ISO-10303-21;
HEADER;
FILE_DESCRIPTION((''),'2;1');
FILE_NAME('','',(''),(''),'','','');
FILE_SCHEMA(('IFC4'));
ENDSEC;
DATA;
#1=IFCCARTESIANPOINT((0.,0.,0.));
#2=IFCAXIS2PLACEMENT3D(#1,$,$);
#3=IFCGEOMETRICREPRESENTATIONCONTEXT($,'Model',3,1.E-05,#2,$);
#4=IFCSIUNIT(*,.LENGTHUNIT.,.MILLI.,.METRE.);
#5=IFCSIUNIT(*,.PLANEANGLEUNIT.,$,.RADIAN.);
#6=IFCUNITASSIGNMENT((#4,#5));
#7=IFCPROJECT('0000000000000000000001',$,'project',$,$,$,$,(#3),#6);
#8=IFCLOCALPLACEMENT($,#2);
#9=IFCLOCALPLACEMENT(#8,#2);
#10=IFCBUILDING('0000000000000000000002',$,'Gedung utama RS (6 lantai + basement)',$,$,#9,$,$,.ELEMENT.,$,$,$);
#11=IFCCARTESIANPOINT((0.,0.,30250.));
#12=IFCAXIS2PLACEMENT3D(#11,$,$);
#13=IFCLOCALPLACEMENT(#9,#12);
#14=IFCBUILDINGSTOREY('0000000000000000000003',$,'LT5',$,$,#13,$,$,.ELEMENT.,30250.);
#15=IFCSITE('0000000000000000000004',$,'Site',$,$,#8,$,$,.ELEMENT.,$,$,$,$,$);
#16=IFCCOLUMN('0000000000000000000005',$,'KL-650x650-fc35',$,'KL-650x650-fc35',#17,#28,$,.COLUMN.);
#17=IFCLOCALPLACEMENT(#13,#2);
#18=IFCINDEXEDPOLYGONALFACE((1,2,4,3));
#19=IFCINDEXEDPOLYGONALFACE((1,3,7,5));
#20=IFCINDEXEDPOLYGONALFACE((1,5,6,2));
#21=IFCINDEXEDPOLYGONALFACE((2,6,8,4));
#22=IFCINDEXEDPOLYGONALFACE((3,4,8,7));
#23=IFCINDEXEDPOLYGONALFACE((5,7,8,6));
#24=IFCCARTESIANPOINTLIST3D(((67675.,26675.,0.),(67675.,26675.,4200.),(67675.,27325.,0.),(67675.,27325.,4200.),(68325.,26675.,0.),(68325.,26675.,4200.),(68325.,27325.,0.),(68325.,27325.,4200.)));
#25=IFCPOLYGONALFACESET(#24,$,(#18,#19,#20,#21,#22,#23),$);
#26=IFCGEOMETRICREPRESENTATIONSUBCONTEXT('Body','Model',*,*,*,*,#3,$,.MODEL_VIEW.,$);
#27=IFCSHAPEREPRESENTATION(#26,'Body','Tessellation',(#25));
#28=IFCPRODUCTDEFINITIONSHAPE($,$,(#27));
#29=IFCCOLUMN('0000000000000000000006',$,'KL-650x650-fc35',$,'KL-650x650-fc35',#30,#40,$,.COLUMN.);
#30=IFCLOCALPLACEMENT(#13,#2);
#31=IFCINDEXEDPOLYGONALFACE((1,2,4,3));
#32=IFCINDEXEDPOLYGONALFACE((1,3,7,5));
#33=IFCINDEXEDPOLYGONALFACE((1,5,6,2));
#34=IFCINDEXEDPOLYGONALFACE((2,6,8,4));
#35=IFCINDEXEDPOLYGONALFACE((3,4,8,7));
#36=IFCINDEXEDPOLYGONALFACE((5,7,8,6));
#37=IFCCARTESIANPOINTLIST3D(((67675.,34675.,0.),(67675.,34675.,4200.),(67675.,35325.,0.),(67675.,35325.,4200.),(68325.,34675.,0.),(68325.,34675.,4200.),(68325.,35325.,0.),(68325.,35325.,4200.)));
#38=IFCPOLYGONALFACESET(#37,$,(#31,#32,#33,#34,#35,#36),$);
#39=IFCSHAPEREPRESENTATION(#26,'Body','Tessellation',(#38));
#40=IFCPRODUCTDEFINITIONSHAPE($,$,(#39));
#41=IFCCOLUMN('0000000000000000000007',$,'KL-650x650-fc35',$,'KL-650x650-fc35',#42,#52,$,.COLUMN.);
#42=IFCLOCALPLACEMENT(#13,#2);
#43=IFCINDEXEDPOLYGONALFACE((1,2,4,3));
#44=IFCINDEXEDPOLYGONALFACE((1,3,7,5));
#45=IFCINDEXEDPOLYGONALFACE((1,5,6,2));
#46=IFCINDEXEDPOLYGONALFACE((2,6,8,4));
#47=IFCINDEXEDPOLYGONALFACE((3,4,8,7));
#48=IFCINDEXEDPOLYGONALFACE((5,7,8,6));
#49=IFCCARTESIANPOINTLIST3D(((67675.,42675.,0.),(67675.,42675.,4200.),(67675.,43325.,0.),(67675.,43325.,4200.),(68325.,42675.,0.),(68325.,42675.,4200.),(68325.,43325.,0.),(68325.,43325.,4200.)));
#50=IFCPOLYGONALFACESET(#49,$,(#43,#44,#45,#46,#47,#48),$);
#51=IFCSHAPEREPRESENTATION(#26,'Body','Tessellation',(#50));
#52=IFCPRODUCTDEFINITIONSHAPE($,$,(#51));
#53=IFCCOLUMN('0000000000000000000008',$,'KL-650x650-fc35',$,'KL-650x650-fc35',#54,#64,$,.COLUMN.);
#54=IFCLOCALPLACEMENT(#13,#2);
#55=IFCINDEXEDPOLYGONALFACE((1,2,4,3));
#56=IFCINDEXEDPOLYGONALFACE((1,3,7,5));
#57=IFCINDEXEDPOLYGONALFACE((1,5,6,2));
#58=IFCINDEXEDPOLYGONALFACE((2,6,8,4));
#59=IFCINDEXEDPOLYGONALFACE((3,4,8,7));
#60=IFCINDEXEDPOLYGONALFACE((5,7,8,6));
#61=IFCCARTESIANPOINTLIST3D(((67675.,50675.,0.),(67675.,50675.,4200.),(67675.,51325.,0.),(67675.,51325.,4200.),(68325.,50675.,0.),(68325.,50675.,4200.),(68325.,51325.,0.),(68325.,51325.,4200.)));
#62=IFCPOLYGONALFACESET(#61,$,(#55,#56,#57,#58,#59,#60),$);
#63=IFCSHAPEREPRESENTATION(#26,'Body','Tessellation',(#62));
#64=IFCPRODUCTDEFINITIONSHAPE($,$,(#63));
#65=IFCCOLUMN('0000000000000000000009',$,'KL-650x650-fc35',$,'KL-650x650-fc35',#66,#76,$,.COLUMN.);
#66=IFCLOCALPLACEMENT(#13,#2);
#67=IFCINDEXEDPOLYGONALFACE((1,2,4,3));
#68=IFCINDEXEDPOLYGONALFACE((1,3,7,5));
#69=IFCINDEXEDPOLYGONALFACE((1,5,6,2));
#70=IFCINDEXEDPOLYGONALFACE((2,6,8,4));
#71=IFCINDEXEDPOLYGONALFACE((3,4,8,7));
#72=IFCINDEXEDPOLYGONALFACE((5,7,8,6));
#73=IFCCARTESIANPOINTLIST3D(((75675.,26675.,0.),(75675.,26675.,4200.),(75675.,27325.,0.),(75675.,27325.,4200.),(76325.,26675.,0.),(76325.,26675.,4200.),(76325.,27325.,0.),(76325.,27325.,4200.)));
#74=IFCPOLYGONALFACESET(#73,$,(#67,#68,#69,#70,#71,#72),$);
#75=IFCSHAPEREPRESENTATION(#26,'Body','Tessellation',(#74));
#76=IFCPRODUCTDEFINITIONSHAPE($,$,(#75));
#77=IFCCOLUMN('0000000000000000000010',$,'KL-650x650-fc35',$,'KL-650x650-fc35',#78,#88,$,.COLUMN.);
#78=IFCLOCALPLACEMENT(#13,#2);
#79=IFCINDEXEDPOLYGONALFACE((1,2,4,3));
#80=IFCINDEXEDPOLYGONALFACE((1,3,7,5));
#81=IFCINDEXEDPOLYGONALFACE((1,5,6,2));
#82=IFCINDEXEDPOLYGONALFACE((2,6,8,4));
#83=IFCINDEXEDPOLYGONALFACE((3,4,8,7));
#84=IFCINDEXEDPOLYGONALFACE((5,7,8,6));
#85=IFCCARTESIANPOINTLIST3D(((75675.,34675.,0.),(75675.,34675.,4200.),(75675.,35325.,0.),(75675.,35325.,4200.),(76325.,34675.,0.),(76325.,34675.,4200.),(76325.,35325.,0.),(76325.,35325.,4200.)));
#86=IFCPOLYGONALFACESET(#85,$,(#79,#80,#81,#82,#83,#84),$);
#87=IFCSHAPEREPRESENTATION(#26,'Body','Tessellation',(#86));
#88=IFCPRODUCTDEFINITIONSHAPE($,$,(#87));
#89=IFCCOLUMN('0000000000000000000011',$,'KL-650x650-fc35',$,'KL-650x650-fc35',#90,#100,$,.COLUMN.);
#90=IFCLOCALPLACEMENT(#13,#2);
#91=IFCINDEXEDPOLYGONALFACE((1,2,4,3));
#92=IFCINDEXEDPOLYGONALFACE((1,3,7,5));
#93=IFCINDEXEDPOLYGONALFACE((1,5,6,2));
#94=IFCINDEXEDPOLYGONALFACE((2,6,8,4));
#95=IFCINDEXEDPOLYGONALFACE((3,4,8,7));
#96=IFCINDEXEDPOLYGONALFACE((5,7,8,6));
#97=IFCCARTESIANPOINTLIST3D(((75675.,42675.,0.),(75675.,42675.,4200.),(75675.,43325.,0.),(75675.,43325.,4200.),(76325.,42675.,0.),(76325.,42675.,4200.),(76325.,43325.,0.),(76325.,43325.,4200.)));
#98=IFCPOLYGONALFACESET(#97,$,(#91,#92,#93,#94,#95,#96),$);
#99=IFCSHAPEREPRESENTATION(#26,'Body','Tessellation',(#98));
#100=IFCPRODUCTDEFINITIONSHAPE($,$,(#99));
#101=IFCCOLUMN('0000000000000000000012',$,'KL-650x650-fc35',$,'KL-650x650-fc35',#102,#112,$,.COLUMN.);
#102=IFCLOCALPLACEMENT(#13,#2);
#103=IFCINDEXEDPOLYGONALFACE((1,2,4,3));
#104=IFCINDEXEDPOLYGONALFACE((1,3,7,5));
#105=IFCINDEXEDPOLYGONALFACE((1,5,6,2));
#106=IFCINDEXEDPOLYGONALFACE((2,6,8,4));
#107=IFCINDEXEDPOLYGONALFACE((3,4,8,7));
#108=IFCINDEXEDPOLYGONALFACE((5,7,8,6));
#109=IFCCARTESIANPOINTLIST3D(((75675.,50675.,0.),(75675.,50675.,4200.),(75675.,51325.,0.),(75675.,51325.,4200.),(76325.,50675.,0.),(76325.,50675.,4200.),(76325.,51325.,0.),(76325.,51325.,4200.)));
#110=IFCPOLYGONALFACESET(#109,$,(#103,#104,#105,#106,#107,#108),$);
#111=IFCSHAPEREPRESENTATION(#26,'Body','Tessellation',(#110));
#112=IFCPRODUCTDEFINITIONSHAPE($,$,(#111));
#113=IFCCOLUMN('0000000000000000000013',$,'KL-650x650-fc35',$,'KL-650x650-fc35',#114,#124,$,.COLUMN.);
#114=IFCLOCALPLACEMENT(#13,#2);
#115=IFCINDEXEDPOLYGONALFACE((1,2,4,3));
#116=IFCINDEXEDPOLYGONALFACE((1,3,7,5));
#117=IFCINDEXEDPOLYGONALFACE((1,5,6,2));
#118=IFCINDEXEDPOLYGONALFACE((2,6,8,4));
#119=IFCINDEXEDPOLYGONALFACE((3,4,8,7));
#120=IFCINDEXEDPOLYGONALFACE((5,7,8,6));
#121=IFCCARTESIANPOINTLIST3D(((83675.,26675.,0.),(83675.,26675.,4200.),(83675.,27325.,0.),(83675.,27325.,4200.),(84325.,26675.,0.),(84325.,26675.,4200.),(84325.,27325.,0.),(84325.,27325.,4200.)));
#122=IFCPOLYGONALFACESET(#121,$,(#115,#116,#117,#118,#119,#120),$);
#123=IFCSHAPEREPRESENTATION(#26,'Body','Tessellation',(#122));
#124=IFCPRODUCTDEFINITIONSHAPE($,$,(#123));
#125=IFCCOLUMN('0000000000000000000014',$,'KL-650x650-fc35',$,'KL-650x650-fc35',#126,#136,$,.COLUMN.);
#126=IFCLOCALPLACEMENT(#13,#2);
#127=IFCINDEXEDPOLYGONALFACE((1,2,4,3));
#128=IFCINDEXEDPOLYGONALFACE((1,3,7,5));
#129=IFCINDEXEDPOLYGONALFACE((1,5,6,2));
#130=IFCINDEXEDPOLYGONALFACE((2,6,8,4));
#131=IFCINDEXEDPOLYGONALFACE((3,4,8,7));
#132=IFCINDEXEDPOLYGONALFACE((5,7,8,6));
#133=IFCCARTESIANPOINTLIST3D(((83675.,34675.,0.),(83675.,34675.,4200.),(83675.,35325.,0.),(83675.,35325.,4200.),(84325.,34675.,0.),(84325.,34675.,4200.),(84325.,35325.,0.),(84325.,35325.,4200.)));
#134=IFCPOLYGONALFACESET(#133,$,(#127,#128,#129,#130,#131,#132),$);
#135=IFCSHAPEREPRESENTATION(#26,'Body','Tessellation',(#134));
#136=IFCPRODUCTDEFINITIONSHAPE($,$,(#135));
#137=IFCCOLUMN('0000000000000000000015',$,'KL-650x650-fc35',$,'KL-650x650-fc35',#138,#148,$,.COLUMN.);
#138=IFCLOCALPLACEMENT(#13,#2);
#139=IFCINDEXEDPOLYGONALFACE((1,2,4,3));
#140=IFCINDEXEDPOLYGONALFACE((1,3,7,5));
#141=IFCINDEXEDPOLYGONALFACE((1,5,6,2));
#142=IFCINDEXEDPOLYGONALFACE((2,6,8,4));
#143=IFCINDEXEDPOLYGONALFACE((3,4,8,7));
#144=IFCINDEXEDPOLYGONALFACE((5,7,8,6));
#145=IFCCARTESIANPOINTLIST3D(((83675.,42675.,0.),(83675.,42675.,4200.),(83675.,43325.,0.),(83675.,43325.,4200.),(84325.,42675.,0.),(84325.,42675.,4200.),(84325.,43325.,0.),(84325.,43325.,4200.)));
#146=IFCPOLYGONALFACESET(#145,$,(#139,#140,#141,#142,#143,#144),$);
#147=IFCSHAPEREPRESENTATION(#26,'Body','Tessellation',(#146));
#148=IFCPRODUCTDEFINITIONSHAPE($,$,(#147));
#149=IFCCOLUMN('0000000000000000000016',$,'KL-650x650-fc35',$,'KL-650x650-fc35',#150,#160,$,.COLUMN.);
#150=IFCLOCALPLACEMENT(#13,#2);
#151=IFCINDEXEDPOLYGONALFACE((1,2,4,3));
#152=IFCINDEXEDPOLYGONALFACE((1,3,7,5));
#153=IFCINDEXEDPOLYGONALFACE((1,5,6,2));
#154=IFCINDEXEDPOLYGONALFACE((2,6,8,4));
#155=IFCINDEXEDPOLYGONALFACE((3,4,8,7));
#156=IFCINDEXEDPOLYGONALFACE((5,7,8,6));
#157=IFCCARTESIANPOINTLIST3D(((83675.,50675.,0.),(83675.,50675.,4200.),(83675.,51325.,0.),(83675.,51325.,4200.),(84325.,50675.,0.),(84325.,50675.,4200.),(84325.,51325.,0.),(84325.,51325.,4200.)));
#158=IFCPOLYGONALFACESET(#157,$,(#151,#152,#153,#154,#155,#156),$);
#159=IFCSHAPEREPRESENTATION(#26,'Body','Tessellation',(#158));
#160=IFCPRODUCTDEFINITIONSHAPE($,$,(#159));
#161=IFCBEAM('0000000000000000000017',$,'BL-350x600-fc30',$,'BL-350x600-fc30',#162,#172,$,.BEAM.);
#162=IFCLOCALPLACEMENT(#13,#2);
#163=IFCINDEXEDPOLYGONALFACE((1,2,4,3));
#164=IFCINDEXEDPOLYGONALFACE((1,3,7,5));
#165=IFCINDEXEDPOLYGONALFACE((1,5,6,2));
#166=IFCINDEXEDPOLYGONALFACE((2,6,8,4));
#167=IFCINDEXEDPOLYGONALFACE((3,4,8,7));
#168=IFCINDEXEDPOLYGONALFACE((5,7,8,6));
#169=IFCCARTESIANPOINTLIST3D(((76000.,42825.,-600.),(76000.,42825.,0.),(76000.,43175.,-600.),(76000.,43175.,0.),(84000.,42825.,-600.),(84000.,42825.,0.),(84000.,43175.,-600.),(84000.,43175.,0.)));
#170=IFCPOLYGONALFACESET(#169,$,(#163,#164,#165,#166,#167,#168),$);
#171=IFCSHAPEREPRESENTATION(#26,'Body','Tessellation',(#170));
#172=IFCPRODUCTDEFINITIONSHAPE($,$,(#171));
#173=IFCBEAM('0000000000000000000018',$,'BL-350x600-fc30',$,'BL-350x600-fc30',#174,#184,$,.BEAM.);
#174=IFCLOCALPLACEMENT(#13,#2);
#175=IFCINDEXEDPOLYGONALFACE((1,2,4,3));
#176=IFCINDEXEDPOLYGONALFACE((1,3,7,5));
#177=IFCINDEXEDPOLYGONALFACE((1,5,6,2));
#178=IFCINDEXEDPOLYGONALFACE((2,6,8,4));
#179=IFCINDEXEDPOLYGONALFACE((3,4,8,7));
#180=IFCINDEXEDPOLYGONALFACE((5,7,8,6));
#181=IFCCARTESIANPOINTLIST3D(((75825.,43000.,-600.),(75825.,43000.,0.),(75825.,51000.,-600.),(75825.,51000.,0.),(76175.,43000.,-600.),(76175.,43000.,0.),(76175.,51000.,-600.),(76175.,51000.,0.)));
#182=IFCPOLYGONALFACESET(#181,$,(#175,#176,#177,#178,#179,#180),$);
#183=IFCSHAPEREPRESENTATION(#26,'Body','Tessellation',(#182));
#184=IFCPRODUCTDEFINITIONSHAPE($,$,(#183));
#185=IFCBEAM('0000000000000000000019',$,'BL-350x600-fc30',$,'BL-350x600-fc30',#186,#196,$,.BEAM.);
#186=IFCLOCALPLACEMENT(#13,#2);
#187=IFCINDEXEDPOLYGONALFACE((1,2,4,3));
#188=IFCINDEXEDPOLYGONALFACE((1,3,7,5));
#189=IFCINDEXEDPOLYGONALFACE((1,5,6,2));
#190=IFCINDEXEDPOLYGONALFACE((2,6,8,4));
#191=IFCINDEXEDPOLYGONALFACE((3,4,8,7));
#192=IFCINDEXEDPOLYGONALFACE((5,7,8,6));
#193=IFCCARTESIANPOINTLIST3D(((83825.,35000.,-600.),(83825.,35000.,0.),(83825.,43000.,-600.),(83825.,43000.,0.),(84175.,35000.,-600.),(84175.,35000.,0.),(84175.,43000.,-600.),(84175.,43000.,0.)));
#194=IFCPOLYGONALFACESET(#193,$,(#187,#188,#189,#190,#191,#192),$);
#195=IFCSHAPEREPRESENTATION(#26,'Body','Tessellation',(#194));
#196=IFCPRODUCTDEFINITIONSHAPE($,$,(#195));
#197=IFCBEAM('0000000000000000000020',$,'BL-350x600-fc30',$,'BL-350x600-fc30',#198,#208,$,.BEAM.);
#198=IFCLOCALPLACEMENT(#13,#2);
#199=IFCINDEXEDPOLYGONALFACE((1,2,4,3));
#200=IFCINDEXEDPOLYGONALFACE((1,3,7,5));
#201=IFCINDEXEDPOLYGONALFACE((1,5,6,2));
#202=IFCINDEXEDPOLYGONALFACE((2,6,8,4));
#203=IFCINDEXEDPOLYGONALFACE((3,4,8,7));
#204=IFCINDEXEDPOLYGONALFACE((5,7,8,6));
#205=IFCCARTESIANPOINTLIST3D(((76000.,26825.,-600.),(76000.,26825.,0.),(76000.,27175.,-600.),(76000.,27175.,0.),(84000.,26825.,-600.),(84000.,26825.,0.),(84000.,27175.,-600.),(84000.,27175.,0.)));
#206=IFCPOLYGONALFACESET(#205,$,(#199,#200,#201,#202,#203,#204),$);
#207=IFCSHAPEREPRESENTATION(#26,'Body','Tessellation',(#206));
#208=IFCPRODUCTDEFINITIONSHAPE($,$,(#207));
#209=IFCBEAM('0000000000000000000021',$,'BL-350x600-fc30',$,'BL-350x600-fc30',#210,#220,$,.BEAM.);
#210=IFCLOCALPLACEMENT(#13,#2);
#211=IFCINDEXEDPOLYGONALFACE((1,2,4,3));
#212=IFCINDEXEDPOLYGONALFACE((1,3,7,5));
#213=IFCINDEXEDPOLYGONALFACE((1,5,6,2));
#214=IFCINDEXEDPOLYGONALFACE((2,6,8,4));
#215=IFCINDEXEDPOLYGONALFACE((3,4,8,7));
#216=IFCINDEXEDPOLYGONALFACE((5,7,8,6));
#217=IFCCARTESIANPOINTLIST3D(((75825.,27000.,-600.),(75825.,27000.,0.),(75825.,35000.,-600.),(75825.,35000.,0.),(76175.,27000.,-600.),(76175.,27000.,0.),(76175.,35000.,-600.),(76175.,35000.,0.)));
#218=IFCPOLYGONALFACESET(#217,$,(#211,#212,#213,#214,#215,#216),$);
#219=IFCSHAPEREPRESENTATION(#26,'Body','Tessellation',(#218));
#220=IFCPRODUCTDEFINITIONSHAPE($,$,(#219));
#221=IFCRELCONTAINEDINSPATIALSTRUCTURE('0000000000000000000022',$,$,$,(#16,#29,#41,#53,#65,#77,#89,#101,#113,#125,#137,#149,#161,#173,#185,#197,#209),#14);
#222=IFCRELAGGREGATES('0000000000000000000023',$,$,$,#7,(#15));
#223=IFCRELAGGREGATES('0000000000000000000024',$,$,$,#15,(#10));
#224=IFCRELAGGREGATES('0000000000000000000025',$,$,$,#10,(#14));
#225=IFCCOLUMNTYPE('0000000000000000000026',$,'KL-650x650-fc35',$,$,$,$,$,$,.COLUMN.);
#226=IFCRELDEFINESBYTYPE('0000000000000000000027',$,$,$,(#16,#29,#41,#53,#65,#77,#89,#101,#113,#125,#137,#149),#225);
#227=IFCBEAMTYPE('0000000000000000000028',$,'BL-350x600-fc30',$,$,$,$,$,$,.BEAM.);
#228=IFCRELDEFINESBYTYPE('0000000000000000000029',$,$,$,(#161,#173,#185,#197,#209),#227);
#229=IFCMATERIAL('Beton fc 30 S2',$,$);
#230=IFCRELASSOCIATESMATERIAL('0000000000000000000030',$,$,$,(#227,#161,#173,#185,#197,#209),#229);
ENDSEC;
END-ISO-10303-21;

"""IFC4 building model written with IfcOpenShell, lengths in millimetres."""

from ifc_helpers import new_model, si_unit, frame, origin, origin_2d, place, context, subcontext, project, spatial, rectangle, extrude, material, material_profile, profile_set, profile_usage, type_object, element, save


model = new_model("IFC4")

# Units and contexts
model_context = context("Model", 3, precision=1e-05, world=origin())
body_context = subcontext(model_context, "Body", "Model", "MODEL_VIEW")
ifc_project = project(units=[si_unit("LENGTHUNIT", "METRE", prefix="MILLI"), si_unit("PLANEANGLEUNIT", "RADIAN")], contexts=[model_context])

# Site, building, storey
site_placement = place(None, origin())
site = spatial("IfcSite", under=ifc_project, at=site_placement, Name="Site", CompositionType="ELEMENT")
building_placement = place(site_placement, origin())
building = spatial("IfcBuilding", under=site, at=building_placement, Name="Gedung utama RS (6 lantai + basement)", CompositionType="ELEMENT")
storey_placement = place(building_placement, frame((0.0, 0.0, 30250.0)))
storey = spatial("IfcBuildingStorey", under=building, at=storey_placement, Name="LT5", CompositionType="ELEMENT", Elevation=30250.0)

# Columns
ifc_material_profile_1 = material_profile(None, rectangle(XDim=650.0, YDim=650.0, at=origin_2d()), Name="KL-650x650-fc35")
ifc_profile_set_1 = profile_set([ifc_material_profile_1], Name="KL-650x650-fc35")
ifc_profile_usage_1 = profile_usage(ifc_profile_set_1, cardinal=5)
column_type = type_object("IfcColumnType", Name="KL-650x650-fc35", PredefinedType="COLUMN", material=ifc_profile_set_1)
for number, where, z_axis, x_axis, name in (
    (1, (68000.0, 27000.0, 0.0), (0.0, 0.0, 1.0), (1.0, 0.0, 0.0), "KL-650x650-fc35"),
    (2, (68000.0, 35000.0, 0.0), (0.0, 0.0, 1.0), (1.0, 0.0, 0.0), "KL-650x650-fc35"),
    (3, (68000.0, 43000.0, 0.0), (0.0, 0.0, 1.0), (1.0, 0.0, 0.0), "KL-650x650-fc35"),
    (4, (68000.0, 51000.0, 0.0), (0.0, 0.0, 1.0), (1.0, 0.0, 0.0), "KL-650x650-fc35"),
    (5, (76000.0, 27000.0, 0.0), (0.0, 0.0, 1.0), (1.0, 0.0, 0.0), "KL-650x650-fc35"),
    (6, (76000.0, 35000.0, 0.0), (0.0, 0.0, 1.0), (1.0, 0.0, 0.0), "KL-650x650-fc35"),
    (7, (76000.0, 43000.0, 0.0), (0.0, 0.0, 1.0), (1.0, 0.0, 0.0), "KL-650x650-fc35"),
    (8, (76000.0, 51000.0, 0.0), (0.0, 0.0, 1.0), (1.0, 0.0, 0.0), "KL-650x650-fc35"),
    (9, (84000.0, 27000.0, 0.0), (0.0, 0.0, 1.0), (1.0, 0.0, 0.0), "KL-650x650-fc35"),
    (10, (84000.0, 35000.0, 0.0), (0.0, 0.0, 1.0), (1.0, 0.0, 0.0), "KL-650x650-fc35"),
    (11, (84000.0, 43000.0, 0.0), (0.0, 0.0, 1.0), (1.0, 0.0, 0.0), "KL-650x650-fc35"),
    (12, (84000.0, 51000.0, 0.0), (0.0, 0.0, 1.0), (1.0, 0.0, 0.0), "KL-650x650-fc35"),
):
    element("IfcColumn", number, at=place(storey_placement, frame(where, z_axis=z_axis, x_axis=x_axis)), inside=storey, type_object=column_type, material=ifc_profile_usage_1, Name=name, ObjectType="KL-650x650-fc35", PredefinedType="COLUMN", context=body_context, shape_type="SweptSolid", body=[
        extrude(rectangle(XDim=650.0, YDim=650.0, at=origin_2d()), origin(), (0.0, 0.0, 1.0), 4200.0),
    ])

# Beams
ifc_material_1 = material(Name="Beton fc 30 S2")
ifc_material_profile_2 = material_profile(ifc_material_1, rectangle(XDim=350.0, YDim=600.0, at=origin_2d()), Name="BL-350x600-fc30")
ifc_profile_set_2 = profile_set([ifc_material_profile_2], Name="BL-350x600-fc30")
ifc_profile_usage_2 = profile_usage(ifc_profile_set_2, cardinal=8)
beam_type = type_object("IfcBeamType", Name="BL-350x600-fc30", PredefinedType="BEAM", material=ifc_profile_set_2)
beam_1_placement = place(storey_placement, frame((76000.0, 43000.0, -300.0)))
element("IfcBeam", 13, at=beam_1_placement, inside=storey, type_object=beam_type, material=ifc_profile_usage_2, Name="BL-350x600-fc30", ObjectType="BL-350x600-fc30", PredefinedType="BEAM", context=body_context, shape_type="SweptSolid", body=[
    extrude(rectangle(XDim=350.0, YDim=600.0, at=origin_2d()), frame((0.0, 0.0, 0.0), z_axis=(1.0, 0.0, 0.0), x_axis=(0.0, 1.0, 0.0)), (0.0, 0.0, 1.0), 8000.0),
])
for number, where, name in (
    (14, (76000.0, 43000.0, -300.0), "BL-350x600-fc30"),
    (15, (84000.0, 35000.0, -300.0), "BL-350x600-fc30"),
):
    element("IfcBeam", number, at=place(storey_placement, frame(where)), inside=storey, type_object=beam_type, material=ifc_profile_usage_2, Name=name, ObjectType="BL-350x600-fc30", PredefinedType="BEAM", context=body_context, shape_type="SweptSolid", body=[
        extrude(rectangle(XDim=350.0, YDim=600.0, at=origin_2d()), frame((0.0, 0.0, 0.0), z_axis=(0.0, 1.0, 0.0), x_axis=(-1.0, 0.0, 0.0)), (0.0, 0.0, 1.0), 8000.0),
    ])
beam_2_placement = place(storey_placement, frame((76000.0, 27000.0, -300.0)))
element("IfcBeam", 16, at=beam_2_placement, inside=storey, type_object=beam_type, material=ifc_profile_usage_2, Name="BL-350x600-fc30", ObjectType="BL-350x600-fc30", PredefinedType="BEAM", context=body_context, shape_type="SweptSolid", body=[
    extrude(rectangle(XDim=350.0, YDim=600.0, at=origin_2d()), frame((0.0, 0.0, 0.0), z_axis=(1.0, 0.0, 0.0), x_axis=(0.0, 1.0, 0.0)), (0.0, 0.0, 1.0), 8000.0),
])
beam_3_placement = place(storey_placement, frame((76000.0, 27000.0, -300.0)))
element("IfcBeam", 17, at=beam_3_placement, inside=storey, type_object=beam_type, material=ifc_profile_usage_2, Name="BL-350x600-fc30", ObjectType="BL-350x600-fc30", PredefinedType="BEAM", context=body_context, shape_type="SweptSolid", body=[
    extrude(rectangle(XDim=350.0, YDim=600.0, at=origin_2d()), frame((0.0, 0.0, 0.0), z_axis=(0.0, 1.0, 0.0), x_axis=(-1.0, 0.0, 0.0)), (0.0, 0.0, 1.0), 8000.0),
])

save(model, "model.ifc")
